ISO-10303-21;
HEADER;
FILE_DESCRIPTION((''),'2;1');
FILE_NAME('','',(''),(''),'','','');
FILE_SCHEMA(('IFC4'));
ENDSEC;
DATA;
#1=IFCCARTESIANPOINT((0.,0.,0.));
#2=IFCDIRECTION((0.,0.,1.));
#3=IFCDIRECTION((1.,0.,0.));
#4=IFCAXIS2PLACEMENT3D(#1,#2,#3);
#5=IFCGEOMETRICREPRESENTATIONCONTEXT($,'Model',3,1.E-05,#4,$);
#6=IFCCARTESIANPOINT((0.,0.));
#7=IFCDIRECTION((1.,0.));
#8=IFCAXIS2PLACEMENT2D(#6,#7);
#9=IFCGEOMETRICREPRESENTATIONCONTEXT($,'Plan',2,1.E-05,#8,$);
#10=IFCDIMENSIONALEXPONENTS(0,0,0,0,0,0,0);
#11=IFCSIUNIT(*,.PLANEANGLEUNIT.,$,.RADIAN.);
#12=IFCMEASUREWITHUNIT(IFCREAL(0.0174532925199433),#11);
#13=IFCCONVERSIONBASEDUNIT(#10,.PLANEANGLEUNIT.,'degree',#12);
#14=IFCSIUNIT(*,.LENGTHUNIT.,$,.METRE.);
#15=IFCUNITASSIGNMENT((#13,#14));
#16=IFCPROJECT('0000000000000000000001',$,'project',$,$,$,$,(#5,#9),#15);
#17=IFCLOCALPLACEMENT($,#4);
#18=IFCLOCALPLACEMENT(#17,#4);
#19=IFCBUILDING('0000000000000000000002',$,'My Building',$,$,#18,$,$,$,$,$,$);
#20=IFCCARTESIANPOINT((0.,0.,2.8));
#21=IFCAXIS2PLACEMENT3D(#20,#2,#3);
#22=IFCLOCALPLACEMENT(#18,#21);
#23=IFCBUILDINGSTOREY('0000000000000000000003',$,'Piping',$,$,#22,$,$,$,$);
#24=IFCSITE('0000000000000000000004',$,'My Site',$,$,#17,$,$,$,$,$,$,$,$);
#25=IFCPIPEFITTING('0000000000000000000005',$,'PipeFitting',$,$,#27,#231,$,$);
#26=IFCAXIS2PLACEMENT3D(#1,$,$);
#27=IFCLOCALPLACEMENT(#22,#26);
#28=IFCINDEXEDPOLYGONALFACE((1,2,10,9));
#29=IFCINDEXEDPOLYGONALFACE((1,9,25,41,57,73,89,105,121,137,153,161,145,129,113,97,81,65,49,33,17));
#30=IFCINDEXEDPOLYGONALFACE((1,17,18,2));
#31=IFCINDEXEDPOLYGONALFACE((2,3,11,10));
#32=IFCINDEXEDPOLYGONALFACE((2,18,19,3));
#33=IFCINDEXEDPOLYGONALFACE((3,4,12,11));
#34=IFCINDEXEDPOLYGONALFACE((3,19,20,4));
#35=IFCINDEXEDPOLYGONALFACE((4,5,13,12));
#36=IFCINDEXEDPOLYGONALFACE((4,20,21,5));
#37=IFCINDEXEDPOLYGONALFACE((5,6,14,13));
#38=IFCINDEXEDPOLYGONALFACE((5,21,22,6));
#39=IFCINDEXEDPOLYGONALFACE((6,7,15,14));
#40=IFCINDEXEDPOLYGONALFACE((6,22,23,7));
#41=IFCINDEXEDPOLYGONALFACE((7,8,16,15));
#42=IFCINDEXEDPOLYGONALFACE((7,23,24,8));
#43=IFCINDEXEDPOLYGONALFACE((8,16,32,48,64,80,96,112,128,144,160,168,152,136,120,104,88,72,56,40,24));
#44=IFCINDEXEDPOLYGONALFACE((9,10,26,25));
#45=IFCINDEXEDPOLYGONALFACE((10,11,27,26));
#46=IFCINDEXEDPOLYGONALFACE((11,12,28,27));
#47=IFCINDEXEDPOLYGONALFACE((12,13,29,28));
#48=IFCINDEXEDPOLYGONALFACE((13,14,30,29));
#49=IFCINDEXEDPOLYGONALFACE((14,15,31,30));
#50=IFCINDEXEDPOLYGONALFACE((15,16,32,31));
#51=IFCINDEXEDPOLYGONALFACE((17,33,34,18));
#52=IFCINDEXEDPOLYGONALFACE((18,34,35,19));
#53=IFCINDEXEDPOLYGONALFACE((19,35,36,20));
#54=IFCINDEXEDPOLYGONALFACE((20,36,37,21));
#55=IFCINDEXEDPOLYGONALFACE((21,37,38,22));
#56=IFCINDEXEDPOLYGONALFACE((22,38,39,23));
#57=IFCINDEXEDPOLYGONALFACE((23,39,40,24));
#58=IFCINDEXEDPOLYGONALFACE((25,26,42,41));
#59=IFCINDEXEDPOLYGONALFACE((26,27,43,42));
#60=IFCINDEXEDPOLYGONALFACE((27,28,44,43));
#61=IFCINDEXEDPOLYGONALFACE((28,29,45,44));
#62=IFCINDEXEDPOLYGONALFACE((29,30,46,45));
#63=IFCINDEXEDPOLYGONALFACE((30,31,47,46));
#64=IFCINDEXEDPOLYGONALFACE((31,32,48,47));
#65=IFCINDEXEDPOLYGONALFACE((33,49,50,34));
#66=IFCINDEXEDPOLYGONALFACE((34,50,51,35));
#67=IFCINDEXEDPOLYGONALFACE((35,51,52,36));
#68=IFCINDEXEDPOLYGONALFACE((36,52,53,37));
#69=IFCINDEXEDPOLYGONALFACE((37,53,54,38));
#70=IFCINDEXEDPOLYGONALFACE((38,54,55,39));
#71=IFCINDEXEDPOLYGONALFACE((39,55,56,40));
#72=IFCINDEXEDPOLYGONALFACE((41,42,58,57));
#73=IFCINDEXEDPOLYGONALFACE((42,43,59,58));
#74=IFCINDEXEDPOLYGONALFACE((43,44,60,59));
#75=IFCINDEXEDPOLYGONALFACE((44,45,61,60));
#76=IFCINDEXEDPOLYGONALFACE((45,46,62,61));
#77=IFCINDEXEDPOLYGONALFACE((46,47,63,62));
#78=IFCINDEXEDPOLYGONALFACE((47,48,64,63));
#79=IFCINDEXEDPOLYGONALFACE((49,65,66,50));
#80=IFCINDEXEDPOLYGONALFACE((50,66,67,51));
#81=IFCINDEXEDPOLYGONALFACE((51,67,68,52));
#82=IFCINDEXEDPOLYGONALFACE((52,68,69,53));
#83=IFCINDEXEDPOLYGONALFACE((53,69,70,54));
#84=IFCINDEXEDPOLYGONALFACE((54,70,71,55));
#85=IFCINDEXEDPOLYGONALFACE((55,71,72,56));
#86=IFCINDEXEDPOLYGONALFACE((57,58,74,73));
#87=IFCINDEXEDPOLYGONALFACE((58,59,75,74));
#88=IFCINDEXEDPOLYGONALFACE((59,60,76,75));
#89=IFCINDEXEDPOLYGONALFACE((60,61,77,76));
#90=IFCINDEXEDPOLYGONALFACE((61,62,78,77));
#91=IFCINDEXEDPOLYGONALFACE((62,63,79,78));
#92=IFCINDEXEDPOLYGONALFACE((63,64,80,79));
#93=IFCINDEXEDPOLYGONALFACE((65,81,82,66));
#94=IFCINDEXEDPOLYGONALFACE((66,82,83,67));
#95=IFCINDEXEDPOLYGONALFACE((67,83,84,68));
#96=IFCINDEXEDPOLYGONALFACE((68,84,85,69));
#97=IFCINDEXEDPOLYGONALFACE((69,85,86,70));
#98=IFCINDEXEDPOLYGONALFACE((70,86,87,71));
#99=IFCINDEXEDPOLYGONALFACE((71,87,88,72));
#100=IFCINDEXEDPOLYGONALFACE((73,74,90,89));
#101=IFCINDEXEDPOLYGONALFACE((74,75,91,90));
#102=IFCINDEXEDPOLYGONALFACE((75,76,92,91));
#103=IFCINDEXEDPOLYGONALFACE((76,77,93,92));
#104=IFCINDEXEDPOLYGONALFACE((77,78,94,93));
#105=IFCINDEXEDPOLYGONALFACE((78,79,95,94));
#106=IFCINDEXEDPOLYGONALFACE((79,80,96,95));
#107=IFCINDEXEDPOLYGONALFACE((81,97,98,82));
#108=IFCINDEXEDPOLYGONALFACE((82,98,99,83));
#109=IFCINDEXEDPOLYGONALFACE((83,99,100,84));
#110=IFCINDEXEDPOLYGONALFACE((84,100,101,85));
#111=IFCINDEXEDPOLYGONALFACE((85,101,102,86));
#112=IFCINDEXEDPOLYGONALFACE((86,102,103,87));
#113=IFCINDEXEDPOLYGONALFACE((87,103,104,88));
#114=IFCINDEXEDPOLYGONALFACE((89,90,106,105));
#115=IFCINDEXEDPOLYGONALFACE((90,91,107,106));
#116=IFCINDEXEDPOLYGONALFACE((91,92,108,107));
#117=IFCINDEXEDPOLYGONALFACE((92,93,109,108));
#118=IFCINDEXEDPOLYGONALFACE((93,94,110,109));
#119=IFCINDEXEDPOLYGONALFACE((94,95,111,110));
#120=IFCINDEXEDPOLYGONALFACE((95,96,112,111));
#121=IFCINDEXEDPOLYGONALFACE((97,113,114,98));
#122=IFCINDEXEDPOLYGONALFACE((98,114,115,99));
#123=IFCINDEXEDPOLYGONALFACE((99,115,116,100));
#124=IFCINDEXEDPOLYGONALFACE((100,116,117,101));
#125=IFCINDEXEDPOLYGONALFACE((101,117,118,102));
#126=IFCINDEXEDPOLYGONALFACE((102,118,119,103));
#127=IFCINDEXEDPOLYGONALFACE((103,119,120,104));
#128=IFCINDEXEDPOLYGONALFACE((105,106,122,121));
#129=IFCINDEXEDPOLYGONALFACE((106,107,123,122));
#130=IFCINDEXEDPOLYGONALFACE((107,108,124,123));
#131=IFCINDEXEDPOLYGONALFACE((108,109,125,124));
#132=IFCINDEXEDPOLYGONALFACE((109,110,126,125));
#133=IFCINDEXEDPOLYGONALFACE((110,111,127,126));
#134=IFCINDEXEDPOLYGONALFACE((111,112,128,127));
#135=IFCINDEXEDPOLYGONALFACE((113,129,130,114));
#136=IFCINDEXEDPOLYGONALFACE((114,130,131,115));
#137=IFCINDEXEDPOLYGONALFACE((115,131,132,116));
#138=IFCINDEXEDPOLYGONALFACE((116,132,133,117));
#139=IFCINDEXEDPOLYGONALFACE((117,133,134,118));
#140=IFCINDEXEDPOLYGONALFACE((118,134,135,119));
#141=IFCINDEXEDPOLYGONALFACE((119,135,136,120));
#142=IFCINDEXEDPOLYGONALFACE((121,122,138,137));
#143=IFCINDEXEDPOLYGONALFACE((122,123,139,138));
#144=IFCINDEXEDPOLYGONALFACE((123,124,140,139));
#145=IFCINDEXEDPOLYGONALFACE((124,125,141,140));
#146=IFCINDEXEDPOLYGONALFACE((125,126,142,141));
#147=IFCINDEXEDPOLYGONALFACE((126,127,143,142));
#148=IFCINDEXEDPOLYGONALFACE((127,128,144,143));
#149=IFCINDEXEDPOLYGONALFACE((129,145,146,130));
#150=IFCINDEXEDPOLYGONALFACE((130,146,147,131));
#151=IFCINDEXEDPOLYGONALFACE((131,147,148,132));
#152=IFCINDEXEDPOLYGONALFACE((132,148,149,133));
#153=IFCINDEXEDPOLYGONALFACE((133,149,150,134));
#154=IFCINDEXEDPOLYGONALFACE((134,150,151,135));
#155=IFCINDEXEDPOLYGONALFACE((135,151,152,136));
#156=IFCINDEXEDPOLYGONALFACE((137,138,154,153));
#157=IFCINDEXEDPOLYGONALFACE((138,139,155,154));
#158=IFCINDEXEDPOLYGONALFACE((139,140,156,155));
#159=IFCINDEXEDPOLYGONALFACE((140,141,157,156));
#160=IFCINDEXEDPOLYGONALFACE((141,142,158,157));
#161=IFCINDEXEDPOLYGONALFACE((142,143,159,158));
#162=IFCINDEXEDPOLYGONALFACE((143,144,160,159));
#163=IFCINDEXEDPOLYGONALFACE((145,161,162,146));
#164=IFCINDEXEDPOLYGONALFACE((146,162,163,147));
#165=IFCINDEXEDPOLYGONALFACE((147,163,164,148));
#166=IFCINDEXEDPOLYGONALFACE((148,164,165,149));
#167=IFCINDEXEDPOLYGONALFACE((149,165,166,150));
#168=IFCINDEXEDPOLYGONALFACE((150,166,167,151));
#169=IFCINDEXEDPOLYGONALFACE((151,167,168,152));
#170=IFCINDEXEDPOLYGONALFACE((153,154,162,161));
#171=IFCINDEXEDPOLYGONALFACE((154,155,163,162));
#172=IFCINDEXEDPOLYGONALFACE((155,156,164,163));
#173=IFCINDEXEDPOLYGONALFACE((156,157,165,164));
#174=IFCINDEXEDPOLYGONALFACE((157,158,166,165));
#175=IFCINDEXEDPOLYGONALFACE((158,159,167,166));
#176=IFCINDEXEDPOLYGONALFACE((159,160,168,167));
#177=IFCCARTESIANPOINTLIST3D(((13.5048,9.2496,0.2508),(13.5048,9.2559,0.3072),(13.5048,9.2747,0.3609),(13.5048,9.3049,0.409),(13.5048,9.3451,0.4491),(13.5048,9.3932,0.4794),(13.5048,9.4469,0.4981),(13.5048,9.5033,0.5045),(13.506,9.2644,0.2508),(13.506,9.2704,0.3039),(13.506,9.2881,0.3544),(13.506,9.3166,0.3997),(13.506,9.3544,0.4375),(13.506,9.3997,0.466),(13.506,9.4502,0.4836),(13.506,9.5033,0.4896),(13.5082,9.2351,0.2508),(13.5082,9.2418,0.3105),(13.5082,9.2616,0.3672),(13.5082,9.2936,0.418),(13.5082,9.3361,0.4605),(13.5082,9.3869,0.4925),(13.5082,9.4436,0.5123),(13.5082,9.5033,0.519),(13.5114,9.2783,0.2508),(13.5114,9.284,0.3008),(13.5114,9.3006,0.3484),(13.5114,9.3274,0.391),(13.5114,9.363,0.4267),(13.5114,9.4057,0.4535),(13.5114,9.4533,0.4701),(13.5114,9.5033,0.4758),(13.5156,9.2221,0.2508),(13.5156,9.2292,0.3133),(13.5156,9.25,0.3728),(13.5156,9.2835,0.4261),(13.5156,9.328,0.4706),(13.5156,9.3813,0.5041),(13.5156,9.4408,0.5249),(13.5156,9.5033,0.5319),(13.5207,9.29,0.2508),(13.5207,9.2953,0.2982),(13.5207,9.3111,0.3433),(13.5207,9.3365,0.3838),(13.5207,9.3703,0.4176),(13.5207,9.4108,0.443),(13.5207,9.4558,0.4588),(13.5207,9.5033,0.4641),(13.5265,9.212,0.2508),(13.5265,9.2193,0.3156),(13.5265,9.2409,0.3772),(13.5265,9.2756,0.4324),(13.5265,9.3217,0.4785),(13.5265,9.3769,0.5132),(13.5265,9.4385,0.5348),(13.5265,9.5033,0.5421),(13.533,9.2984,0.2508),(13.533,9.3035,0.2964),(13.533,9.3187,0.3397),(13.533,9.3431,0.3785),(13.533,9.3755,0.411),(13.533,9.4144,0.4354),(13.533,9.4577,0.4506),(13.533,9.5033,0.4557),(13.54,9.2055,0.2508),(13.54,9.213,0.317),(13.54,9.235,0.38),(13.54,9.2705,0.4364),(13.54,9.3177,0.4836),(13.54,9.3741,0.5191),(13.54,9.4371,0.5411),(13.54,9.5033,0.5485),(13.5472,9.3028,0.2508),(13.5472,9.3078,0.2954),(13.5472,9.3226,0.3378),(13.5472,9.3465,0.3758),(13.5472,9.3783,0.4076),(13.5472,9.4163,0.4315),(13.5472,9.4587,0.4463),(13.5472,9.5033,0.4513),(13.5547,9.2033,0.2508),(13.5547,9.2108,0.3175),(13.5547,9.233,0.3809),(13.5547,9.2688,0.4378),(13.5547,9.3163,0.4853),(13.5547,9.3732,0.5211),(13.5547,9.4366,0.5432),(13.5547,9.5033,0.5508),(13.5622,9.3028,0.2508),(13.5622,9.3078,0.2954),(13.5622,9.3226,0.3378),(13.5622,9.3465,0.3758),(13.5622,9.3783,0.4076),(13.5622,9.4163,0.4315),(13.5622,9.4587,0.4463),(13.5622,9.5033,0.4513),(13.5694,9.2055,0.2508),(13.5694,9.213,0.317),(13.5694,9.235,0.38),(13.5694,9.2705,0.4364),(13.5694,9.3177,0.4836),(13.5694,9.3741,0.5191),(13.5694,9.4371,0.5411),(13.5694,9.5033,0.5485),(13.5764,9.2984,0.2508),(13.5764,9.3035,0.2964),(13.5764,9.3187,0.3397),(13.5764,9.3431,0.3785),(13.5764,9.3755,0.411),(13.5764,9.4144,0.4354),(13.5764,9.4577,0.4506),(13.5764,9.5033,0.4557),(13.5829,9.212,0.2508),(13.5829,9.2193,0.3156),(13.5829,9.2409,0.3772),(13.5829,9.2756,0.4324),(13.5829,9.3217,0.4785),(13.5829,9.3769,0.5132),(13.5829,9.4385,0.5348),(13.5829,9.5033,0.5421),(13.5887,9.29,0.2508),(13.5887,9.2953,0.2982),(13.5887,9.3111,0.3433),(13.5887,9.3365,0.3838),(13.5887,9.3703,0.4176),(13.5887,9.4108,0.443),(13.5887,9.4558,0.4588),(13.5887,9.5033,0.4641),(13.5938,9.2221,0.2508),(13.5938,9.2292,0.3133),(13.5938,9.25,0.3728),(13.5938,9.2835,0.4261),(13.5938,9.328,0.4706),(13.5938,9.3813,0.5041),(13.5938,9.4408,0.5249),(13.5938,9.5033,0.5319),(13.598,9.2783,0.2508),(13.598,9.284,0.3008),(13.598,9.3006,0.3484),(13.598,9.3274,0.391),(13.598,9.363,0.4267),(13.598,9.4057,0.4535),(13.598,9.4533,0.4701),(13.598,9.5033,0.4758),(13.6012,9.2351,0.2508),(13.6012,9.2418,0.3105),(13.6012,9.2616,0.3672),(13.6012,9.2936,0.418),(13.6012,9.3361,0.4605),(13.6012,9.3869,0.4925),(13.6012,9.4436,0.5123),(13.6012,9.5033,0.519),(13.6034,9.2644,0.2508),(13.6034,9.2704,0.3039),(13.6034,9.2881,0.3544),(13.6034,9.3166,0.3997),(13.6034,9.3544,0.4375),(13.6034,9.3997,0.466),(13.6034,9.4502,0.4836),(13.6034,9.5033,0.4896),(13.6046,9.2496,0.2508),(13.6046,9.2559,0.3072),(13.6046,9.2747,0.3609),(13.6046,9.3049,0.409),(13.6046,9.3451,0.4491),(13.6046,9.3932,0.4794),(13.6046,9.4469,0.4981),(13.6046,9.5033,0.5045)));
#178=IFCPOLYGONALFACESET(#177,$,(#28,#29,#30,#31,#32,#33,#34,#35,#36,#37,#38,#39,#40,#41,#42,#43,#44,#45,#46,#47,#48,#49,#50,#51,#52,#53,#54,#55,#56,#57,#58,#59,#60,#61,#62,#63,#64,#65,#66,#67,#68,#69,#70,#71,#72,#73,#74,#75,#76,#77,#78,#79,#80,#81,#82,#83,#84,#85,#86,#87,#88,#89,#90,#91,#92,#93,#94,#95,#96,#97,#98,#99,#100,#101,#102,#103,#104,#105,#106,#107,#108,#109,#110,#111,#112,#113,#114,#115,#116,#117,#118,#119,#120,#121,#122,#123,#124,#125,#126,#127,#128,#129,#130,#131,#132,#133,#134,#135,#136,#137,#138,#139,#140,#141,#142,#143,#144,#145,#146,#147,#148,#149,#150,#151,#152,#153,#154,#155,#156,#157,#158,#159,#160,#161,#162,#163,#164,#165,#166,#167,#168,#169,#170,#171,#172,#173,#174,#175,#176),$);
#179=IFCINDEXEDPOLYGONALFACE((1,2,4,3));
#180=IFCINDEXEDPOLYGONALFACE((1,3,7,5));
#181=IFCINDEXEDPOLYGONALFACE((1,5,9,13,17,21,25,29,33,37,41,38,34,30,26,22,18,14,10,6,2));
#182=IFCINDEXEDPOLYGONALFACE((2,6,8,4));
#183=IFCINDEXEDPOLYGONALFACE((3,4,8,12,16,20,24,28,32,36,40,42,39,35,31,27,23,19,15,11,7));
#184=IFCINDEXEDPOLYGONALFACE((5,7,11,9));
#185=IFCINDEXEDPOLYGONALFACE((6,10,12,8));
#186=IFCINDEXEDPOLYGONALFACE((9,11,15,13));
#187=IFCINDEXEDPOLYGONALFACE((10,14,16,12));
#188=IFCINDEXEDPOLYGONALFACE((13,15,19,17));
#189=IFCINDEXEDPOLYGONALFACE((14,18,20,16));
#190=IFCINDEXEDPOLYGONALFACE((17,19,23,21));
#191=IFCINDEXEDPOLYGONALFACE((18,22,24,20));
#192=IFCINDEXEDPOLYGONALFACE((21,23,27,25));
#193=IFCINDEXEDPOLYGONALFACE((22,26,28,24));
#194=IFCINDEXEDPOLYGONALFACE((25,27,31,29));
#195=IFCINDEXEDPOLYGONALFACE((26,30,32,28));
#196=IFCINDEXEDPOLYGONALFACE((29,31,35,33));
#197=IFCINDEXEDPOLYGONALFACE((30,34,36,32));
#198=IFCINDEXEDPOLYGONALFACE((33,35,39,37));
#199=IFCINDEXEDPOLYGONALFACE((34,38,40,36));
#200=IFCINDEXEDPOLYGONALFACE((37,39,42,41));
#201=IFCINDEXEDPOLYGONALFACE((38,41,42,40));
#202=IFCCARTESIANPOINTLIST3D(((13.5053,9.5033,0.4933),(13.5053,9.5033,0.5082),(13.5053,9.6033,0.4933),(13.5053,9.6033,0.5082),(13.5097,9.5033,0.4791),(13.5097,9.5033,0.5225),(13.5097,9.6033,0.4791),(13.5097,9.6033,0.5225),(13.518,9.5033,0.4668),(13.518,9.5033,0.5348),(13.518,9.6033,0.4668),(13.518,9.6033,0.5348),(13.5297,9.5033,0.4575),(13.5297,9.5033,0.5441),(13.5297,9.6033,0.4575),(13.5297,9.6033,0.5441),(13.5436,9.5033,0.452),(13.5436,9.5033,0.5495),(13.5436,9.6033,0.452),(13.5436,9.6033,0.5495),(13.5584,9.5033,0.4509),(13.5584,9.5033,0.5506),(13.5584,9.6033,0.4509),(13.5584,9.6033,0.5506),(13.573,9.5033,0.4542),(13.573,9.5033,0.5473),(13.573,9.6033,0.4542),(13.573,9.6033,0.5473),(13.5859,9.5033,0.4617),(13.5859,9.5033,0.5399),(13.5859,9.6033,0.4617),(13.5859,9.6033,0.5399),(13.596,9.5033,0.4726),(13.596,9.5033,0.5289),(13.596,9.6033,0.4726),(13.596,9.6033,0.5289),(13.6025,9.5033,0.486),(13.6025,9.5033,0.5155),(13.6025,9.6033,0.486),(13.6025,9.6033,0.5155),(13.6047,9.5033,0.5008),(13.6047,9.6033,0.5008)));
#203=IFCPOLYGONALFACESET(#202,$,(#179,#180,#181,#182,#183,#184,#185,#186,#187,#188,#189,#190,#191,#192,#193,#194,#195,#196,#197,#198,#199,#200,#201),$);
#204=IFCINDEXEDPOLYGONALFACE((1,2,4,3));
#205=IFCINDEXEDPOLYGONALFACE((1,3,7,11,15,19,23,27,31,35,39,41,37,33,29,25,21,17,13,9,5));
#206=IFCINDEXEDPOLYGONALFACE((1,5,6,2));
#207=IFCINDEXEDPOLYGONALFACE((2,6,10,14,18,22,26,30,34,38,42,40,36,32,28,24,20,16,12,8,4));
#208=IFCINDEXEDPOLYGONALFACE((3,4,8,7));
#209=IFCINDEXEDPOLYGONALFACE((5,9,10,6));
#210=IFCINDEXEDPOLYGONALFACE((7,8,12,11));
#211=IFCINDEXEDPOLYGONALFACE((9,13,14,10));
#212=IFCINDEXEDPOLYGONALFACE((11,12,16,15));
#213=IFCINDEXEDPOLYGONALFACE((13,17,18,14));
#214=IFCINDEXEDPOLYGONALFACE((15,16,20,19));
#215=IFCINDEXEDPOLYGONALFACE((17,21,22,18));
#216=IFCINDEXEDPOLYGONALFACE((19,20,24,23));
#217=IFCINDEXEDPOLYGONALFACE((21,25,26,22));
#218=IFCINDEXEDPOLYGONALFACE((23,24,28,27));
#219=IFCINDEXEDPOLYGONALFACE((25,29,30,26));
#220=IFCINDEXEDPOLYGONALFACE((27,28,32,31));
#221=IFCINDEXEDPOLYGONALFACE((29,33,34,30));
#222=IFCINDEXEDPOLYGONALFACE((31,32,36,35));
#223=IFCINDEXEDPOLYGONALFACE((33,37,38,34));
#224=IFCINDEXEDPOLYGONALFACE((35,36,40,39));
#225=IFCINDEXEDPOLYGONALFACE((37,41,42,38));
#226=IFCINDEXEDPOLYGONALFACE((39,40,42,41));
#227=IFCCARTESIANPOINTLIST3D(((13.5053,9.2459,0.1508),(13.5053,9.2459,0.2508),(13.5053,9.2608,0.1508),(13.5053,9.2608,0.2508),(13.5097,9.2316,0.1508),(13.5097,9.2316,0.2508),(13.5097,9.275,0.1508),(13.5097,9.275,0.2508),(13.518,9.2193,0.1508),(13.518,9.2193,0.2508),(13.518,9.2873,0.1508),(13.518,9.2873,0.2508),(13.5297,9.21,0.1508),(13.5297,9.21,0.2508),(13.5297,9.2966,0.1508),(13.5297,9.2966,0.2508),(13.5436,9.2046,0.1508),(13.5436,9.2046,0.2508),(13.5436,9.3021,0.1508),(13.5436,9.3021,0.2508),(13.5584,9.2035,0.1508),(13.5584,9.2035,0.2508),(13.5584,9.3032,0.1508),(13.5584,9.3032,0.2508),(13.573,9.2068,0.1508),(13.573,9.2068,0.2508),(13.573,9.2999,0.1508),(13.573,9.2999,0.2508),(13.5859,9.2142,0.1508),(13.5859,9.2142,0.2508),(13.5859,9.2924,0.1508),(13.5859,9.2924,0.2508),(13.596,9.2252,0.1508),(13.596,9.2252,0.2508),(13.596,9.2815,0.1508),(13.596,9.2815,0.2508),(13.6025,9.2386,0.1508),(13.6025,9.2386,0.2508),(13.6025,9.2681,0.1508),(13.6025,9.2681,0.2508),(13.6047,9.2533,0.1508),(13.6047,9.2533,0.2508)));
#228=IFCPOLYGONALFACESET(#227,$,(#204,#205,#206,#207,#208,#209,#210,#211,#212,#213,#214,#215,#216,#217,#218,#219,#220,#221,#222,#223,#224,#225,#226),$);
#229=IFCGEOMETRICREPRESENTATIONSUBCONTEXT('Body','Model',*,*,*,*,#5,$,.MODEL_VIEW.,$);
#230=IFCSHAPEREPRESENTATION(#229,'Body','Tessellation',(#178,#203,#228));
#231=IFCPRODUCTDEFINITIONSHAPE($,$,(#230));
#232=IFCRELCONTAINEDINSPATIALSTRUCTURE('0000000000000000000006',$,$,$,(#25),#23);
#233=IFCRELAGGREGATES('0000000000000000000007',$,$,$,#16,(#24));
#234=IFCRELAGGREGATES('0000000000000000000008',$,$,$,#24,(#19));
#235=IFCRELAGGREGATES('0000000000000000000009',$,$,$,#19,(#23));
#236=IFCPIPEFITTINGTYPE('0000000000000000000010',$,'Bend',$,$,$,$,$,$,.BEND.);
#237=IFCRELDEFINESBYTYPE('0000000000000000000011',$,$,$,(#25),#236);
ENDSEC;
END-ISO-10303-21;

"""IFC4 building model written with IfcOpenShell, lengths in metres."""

from ifc_helpers import new_model, entity, si_unit, converted_unit, frame, origin_with_axes, origin_2d_with_axis, place, context, subcontext, project, spatial, circle, extrude, source, transform, mapped, type_object, type_shapes, element, save


model = new_model("IFC4")

# Units and contexts
model_context = context("Model", 3, precision=1e-05, world=origin_with_axes())
plan_context = context("Plan", 2, precision=1e-05, world=origin_2d_with_axis())
body_context = subcontext(model_context, "Body", "Model", "MODEL_VIEW")
ifc_project = project(units=[converted_unit("PLANEANGLEUNIT", "degree", entity("IfcReal", 0.0174532925199433), si_unit("PLANEANGLEUNIT", "RADIAN"), dimensions=[0, 0, 0, 0, 0, 0, 0]), si_unit("LENGTHUNIT", "METRE")], contexts=[model_context, plan_context])

# Site, building, storey
site_placement = place(None, origin_with_axes())
site = spatial("IfcSite", under=ifc_project, at=site_placement, Name="My Site")
building_placement = place(site_placement, origin_with_axes())
building = spatial("IfcBuilding", under=site, at=building_placement, Name="My Building")
storey_placement = place(building_placement, frame((0.0, 0.0, 2.8), z_axis=(0.0, 0.0, 1.0), x_axis=(1.0, 0.0, 0.0)))
storey = spatial("IfcBuildingStorey", under=building, at=storey_placement, Name="Piping")

# Pipe fitting
pipe_fitting_type_1 = type_object("IfcPipeFittingType", Name="Bend", PredefinedType="BEND")
shared_shape_1 = source(origin_with_axes(), body_context, "Body", "SolidModel", [
    entity("IfcSweptDiskSolid", entity("IfcIndexedPolyCurve", entity("IfcCartesianPointList3D", [[0.0, 0.0, 0.1], [0.0, -0.0732, 0.2768], [0.0, -0.25, 0.35]]), [entity("IfcArcIndex", [1, 2, 3])]), 0.05),
    extrude(circle(Radius=0.05), origin_with_axes(), (0.0, 0.0, 1.0), 0.1),
    extrude(circle(Radius=0.05), frame((0.0, -0.25, 0.35), z_axis=(0.0, -1.0, 0.0), x_axis=(1.0, 0.0, 0.0)), (0.0, 0.0, 1.0), 0.1),
])
type_shapes(pipe_fitting_type_1, [shared_shape_1])
for number, where, z_axis, x_axis, name in (
    (1, (13.5547, 9.6033, 0.5008), (0.0, -1.0, 0.0), (1.0, 0.0, 0.0), "PipeFitting"),
):
    element("IfcPipeFitting", number, at=place(storey_placement, frame(where, z_axis=z_axis, x_axis=x_axis)), inside=storey, type_object=pipe_fitting_type_1, Name=name, context=body_context, shape_type="MappedRepresentation", body=[
        mapped(shared_shape_1, transform((0.0, 0.0, 0.0), x_axis=(1.0, 0.0, 0.0), y_axis=(0.0, 1.0, 0.0), z_axis=(0.0, 0.0, 1.0), scale=1.0)),
    ])

save(model, "model.ifc")
